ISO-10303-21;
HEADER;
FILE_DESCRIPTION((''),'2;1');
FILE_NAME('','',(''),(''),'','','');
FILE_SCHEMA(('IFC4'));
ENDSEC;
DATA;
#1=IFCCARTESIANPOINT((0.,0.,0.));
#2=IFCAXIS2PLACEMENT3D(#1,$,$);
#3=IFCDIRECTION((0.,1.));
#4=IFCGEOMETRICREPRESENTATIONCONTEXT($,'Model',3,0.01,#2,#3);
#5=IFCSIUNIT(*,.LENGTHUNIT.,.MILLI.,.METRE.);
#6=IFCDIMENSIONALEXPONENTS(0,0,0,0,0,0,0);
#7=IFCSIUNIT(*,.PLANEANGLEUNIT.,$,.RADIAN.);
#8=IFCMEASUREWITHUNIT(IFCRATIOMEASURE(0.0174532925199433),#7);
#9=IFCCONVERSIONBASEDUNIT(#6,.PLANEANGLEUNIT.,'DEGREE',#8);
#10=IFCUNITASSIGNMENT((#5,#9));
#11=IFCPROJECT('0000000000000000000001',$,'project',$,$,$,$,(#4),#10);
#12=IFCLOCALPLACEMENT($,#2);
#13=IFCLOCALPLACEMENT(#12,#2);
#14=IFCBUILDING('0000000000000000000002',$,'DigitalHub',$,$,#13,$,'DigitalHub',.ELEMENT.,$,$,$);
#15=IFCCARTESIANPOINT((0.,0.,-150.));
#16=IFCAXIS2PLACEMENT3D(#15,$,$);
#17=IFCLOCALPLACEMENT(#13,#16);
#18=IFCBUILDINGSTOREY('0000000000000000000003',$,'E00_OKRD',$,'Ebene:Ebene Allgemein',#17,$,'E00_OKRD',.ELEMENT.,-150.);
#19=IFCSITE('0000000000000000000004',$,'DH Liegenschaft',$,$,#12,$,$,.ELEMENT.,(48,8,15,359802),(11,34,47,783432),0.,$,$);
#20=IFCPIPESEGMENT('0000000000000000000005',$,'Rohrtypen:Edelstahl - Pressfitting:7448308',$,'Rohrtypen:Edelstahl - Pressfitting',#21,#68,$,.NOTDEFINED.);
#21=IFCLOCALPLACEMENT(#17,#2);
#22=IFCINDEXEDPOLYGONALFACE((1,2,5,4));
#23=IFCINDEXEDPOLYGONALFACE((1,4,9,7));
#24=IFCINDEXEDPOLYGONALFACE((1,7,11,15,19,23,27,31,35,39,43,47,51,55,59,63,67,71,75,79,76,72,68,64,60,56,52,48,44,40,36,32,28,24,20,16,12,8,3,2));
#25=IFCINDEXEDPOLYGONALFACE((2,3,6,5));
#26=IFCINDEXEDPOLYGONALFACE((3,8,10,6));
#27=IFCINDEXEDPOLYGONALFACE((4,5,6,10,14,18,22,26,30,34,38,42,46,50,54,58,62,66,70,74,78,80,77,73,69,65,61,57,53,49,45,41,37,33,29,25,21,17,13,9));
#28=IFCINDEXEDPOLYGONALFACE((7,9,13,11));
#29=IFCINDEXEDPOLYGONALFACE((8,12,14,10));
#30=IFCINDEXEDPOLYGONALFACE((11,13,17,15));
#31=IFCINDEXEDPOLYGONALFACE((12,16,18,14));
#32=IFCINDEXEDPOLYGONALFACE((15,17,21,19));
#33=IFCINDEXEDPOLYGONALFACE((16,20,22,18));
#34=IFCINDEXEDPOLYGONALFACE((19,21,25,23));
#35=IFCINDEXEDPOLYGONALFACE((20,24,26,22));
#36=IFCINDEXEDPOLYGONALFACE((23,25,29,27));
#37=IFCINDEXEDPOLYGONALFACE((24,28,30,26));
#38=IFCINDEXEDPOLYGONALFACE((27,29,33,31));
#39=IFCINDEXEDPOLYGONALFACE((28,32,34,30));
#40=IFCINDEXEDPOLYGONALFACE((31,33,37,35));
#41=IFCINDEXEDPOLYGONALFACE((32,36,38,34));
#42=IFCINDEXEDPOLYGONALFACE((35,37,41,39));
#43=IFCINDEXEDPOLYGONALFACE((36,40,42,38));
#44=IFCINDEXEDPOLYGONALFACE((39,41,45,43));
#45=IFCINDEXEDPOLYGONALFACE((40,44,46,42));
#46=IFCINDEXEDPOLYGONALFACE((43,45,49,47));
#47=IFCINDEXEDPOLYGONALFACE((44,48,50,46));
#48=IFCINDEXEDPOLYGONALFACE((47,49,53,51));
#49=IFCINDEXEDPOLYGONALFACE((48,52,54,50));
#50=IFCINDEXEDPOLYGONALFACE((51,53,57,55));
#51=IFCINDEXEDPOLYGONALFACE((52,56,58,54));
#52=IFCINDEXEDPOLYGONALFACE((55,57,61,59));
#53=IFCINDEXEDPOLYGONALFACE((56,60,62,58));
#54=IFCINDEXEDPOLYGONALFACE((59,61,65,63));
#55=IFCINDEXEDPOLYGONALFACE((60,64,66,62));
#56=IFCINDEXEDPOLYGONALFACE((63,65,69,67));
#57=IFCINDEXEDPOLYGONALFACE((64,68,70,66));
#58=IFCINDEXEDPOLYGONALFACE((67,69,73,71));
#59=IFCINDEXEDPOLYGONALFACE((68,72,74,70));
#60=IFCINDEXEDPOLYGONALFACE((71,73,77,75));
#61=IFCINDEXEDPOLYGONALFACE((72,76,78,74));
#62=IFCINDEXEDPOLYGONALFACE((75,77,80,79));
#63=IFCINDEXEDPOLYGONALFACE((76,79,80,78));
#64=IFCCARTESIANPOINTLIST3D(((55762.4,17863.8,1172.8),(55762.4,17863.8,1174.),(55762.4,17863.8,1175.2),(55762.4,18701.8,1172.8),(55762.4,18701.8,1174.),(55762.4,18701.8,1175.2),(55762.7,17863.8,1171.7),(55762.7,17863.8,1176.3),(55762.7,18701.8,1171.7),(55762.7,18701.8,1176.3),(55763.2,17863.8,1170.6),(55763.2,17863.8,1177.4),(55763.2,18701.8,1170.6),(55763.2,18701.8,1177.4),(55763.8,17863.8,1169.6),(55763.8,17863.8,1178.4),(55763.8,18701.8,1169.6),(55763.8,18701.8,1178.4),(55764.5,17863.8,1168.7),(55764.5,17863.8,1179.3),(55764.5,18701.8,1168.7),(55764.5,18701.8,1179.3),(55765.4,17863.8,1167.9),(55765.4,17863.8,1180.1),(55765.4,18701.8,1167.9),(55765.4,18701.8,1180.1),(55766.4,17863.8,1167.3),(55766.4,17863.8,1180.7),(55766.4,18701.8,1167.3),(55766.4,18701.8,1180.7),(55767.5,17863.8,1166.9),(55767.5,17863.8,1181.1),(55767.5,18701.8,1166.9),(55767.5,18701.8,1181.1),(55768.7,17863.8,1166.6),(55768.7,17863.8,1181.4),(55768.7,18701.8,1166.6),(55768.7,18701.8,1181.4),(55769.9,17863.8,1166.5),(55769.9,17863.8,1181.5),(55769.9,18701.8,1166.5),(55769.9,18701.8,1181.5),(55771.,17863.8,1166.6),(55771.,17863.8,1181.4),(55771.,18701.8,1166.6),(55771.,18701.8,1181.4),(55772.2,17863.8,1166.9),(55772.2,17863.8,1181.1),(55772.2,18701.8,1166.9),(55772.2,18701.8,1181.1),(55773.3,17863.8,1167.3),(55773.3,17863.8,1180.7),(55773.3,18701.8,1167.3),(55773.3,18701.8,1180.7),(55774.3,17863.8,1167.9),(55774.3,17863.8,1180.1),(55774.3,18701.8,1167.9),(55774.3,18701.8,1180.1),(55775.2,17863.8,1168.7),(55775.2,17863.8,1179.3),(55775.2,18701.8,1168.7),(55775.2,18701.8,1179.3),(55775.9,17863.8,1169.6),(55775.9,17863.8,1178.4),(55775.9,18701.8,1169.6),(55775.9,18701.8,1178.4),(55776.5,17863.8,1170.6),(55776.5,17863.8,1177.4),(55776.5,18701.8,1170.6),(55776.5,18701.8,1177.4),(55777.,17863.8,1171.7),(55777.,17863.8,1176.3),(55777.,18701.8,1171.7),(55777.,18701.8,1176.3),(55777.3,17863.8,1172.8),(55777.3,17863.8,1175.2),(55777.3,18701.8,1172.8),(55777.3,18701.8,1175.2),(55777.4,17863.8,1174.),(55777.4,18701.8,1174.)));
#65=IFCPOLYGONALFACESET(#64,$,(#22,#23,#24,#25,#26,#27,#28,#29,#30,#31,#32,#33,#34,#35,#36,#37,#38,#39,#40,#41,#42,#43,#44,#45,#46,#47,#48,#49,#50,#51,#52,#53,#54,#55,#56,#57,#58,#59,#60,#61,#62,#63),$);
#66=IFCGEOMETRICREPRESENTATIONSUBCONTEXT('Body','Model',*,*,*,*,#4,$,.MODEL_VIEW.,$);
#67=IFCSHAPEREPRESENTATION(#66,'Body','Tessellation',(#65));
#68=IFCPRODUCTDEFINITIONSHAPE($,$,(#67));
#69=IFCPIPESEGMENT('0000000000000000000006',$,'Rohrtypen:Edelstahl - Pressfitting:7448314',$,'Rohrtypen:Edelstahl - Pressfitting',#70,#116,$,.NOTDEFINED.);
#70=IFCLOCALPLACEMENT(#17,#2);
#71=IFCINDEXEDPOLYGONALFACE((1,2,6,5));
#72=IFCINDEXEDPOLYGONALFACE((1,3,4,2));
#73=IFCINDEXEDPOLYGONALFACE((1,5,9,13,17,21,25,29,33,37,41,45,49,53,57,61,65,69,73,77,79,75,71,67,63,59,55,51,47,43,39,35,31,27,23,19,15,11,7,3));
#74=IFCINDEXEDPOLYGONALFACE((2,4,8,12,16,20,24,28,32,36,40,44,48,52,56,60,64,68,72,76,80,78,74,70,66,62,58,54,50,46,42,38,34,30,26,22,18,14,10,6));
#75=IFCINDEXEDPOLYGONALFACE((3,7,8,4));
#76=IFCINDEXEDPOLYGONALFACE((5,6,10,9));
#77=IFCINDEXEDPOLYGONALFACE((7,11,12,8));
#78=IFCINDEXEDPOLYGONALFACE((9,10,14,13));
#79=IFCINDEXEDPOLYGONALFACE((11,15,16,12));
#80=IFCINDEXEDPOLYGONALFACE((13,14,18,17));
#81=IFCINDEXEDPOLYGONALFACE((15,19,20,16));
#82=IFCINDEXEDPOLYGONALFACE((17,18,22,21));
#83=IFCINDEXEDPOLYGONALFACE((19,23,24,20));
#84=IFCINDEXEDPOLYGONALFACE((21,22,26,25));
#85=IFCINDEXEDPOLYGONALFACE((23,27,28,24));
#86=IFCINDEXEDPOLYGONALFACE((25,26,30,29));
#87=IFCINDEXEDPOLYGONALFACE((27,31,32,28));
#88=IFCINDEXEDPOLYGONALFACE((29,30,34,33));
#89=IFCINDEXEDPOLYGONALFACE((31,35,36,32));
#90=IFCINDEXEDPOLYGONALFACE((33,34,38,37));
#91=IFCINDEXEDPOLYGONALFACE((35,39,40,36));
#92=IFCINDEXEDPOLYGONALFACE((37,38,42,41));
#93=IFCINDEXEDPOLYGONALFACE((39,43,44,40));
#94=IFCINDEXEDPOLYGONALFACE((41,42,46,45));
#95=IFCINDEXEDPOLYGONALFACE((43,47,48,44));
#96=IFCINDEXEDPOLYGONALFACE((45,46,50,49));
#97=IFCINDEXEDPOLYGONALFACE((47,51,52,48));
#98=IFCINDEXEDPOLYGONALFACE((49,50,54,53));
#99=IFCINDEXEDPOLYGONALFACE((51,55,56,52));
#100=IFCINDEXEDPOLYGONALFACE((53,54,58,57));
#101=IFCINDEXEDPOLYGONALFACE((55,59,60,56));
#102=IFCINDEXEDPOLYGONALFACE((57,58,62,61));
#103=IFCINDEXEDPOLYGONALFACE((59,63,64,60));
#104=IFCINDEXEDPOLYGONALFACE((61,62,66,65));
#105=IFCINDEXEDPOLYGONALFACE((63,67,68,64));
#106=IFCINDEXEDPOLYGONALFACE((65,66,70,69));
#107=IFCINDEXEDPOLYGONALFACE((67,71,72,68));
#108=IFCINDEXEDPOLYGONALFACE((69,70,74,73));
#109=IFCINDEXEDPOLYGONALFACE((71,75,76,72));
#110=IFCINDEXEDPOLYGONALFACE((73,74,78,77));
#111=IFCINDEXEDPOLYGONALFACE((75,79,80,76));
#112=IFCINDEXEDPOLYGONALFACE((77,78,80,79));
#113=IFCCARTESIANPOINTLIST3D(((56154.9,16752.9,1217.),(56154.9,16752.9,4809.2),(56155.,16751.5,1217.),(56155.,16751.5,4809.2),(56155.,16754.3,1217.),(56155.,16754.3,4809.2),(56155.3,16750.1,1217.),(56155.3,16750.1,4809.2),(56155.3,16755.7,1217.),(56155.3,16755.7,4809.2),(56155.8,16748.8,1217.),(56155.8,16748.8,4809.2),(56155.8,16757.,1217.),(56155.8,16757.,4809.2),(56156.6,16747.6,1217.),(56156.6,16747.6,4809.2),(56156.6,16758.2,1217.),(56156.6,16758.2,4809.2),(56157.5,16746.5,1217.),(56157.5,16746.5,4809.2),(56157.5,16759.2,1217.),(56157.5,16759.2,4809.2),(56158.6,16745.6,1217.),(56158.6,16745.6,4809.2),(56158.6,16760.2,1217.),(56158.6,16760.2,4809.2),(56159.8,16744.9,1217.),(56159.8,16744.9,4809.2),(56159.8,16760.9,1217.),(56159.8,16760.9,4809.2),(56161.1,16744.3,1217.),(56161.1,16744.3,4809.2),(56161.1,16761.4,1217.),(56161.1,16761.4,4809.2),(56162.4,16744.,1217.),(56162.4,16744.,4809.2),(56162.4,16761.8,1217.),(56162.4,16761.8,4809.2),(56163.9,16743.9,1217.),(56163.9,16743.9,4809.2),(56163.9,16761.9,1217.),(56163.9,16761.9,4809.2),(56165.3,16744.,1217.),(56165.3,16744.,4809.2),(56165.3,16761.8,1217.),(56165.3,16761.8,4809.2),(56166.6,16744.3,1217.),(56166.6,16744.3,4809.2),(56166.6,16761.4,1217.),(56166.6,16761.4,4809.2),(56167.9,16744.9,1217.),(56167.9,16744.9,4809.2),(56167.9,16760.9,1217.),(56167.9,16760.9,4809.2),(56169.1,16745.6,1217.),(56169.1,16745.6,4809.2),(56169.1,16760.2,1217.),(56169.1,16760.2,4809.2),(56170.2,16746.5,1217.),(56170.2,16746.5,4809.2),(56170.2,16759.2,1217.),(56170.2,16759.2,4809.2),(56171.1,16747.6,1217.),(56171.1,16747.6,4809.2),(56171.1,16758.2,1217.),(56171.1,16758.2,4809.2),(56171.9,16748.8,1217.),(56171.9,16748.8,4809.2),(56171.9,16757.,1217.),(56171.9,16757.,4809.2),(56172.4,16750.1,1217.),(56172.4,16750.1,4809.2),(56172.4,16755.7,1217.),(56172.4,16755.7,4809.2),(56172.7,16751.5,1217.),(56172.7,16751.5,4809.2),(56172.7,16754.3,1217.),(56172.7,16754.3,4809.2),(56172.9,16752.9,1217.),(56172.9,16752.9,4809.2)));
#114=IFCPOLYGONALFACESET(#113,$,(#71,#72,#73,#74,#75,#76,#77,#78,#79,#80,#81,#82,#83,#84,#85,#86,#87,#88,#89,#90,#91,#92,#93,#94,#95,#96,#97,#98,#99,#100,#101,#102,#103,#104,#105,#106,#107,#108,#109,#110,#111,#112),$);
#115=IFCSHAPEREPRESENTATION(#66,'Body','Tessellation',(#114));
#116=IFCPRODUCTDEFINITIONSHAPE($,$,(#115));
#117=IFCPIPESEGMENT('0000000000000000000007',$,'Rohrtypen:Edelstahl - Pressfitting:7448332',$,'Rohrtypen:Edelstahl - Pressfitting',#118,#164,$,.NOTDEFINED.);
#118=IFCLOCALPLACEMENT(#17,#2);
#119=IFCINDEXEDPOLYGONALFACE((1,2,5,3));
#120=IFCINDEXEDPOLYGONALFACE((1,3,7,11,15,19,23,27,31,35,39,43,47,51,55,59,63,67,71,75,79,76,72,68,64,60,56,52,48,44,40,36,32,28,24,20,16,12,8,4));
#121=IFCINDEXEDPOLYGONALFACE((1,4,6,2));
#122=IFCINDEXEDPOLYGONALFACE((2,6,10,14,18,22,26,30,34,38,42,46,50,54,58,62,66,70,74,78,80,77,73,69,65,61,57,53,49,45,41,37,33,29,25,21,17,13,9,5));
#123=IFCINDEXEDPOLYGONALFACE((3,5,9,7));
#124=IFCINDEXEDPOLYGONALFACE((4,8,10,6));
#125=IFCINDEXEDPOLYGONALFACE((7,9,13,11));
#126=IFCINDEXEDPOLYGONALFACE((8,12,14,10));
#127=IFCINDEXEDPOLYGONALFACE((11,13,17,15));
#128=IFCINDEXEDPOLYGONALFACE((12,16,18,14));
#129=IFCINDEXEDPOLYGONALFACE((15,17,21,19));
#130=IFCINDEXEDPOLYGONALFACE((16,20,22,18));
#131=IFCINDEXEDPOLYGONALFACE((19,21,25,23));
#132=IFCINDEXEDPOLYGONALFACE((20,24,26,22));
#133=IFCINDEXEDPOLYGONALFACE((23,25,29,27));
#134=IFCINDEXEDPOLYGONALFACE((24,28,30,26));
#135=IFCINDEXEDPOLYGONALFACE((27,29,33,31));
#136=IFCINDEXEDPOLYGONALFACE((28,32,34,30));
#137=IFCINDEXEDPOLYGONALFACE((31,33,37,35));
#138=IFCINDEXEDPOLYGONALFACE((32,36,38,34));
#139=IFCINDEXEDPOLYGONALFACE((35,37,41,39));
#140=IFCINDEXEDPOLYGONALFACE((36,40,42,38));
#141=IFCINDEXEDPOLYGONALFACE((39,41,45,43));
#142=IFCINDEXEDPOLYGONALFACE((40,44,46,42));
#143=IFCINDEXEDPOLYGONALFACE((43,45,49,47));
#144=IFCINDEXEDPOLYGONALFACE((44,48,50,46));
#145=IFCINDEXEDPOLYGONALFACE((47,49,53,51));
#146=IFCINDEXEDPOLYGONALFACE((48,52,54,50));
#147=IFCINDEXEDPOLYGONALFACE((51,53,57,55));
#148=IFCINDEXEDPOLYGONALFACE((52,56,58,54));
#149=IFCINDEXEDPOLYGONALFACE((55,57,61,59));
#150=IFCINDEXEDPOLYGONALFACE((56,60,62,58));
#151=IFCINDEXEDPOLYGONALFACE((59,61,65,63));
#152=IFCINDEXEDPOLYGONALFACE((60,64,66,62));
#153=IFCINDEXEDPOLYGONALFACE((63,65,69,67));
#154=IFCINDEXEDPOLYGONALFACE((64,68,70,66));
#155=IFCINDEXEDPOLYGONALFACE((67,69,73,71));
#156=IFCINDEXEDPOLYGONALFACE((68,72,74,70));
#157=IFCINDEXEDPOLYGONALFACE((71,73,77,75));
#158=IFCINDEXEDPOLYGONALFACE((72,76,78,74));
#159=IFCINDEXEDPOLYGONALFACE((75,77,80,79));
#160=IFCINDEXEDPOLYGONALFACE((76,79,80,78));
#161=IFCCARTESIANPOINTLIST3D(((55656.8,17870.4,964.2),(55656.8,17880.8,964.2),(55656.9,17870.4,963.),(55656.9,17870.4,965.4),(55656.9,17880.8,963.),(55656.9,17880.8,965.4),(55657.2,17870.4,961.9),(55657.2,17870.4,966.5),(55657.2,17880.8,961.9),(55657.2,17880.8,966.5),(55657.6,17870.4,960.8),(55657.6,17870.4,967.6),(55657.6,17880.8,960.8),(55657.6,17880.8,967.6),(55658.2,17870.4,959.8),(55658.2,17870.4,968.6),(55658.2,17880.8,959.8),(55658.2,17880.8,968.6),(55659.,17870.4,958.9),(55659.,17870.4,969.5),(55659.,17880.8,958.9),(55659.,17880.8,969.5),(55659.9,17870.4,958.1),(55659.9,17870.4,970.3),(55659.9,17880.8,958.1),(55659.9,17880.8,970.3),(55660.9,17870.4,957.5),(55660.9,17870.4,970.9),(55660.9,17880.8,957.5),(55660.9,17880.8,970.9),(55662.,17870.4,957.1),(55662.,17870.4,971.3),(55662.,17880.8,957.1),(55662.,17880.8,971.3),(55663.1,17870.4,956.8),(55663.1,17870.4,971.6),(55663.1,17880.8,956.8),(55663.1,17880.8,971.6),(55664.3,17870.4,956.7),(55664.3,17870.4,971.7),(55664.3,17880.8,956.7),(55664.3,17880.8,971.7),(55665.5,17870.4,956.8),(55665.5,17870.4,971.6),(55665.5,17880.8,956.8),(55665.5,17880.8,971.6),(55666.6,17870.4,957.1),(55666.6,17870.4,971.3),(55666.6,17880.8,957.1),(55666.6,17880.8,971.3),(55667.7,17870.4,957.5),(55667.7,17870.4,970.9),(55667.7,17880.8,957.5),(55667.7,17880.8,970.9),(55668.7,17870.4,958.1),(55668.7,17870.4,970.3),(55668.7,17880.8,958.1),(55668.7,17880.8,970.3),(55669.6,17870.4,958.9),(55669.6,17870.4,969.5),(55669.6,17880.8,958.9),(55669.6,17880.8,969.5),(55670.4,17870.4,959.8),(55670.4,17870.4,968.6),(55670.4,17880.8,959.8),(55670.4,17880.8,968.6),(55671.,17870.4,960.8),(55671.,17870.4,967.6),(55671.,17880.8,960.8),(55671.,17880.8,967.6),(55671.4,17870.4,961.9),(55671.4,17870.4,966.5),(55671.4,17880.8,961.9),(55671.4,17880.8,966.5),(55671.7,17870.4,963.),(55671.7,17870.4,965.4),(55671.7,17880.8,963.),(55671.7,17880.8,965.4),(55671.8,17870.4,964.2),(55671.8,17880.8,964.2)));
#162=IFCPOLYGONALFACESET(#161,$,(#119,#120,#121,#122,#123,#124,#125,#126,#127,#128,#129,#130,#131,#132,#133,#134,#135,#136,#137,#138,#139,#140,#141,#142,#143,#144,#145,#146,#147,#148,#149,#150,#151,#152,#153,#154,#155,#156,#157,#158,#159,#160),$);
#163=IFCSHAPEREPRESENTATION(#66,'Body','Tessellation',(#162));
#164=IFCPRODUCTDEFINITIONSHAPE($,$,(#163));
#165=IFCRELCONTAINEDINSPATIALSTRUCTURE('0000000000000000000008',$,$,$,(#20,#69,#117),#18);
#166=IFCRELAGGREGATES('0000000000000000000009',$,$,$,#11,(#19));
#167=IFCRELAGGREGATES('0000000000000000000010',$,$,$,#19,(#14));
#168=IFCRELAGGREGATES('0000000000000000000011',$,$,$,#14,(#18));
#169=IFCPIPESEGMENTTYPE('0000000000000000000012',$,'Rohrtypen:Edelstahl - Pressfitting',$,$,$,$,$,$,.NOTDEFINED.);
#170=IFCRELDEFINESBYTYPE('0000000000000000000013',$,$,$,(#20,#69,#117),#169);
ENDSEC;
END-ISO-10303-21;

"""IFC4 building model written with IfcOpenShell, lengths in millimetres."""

from ifc_helpers import new_model, entity, si_unit, converted_unit, direction, frame, origin, place, context, subcontext, project, spatial, indexed_curve, outline, extrude, type_object, element, save


model = new_model("IFC4")

# Units and contexts
model_context = context("Model", 3, precision=0.01, world=origin(), true_north=direction((0.0, 1.0)))
body_context = subcontext(model_context, "Body", "Model", "MODEL_VIEW")
ifc_project = project(units=[si_unit("LENGTHUNIT", "METRE", prefix="MILLI"), converted_unit("PLANEANGLEUNIT", "DEGREE", entity("IfcRatioMeasure", 0.0174532925199433), si_unit("PLANEANGLEUNIT", "RADIAN"), dimensions=[0, 0, 0, 0, 0, 0, 0])], contexts=[model_context])

# Site, building, storey
site_placement = place(None, origin())
site = spatial("IfcSite", under=ifc_project, at=site_placement, Name="DH Liegenschaft", CompositionType="ELEMENT", RefLatitude=(48, 8, 15, 359802), RefLongitude=(11, 34, 47, 783432), RefElevation=0.0)
building_placement = place(site_placement, origin())
building = spatial("IfcBuilding", under=site, at=building_placement, Name="DigitalHub", LongName="DigitalHub", CompositionType="ELEMENT")
storey_placement = place(building_placement, frame((0.0, 0.0, -150.0)))
storey = spatial("IfcBuildingStorey", under=building, at=storey_placement, Name="E00_OKRD", ObjectType="Ebene:Ebene Allgemein", LongName="E00_OKRD", CompositionType="ELEMENT", Elevation=-150.0)

# Pipe segments
pipe_segment_type_1 = type_object("IfcPipeSegmentType", Name="Rohrtypen:Edelstahl - Pressfitting", PredefinedType="NOTDEFINED")
pipe_segment_1_placement = place(storey_placement, frame((55760.8, 17863.8, 1164.9)))
element("IfcPipeSegment", 1, at=pipe_segment_1_placement, inside=storey, type_object=pipe_segment_type_1, Name="Rohrtypen:Edelstahl - Pressfitting:7448308", ObjectType="Rohrtypen:Edelstahl - Pressfitting", PredefinedType="NOTDEFINED", context=body_context, shape_type="SweptSolid", body=[
    extrude(outline(indexed_curve([(7.5, 0.0), (7.4, 1.2), (7.1, 2.3), (6.7, 3.4), (6.1, 4.4), (5.3, 5.3), (4.4, 6.1), (3.4, 6.7), (2.3, 7.1), (1.2, 7.4), (0.0, 7.5), (-1.2, 7.4), (-2.3, 7.1), (-3.4, 6.7), (-4.4, 6.1), (-5.3, 5.3), (-6.1, 4.4), (-6.7, 3.4), (-7.1, 2.3), (-7.4, 1.2), (-7.5, 0.0), (-7.4, -1.2), (-7.1, -2.3), (-6.7, -3.4), (-6.1, -4.4), (-5.3, -5.3), (-4.4, -6.1), (-3.4, -6.7), (-2.3, -7.1), (-1.2, -7.4), (0.0, -7.5), (1.2, -7.4), (2.3, -7.1), (3.4, -6.7), (4.4, -6.1), (5.3, -5.3), (6.1, -4.4), (6.7, -3.4), (7.1, -2.3), (7.4, -1.2), (7.5, 0.0)], self_intersect=False)), frame((9.1, 0.0, 9.1), z_axis=(0.0, 1.0, 0.0), x_axis=(1.0, 0.0, 0.0)), (0.0, 0.0, 1.0), 838.0),
])
pipe_segment_2_placement = place(storey_placement, frame((56153.3, 16742.3, 1217.0)))
element("IfcPipeSegment", 2, at=pipe_segment_2_placement, inside=storey, type_object=pipe_segment_type_1, Name="Rohrtypen:Edelstahl - Pressfitting:7448314", ObjectType="Rohrtypen:Edelstahl - Pressfitting", PredefinedType="NOTDEFINED", context=body_context, shape_type="SweptSolid", body=[
    extrude(outline(indexed_curve([(9.0, 0.0), (8.9, 1.4), (8.6, 2.8), (8.0, 4.1), (7.3, 5.3), (6.4, 6.4), (5.3, 7.3), (4.1, 8.0), (2.8, 8.6), (1.4, 8.9), (0.0, 9.0), (-1.4, 8.9), (-2.8, 8.6), (-4.1, 8.0), (-5.3, 7.3), (-6.4, 6.4), (-7.3, 5.3), (-8.0, 4.1), (-8.6, 2.8), (-8.9, 1.4), (-9.0, 0.0), (-8.9, -1.4), (-8.6, -2.8), (-8.0, -4.1), (-7.3, -5.3), (-6.4, -6.4), (-5.3, -7.3), (-4.1, -8.0), (-2.8, -8.6), (-1.4, -8.9), (0.0, -9.0), (1.4, -8.9), (2.8, -8.6), (4.1, -8.0), (5.3, -7.3), (6.4, -6.4), (7.3, -5.3), (8.0, -4.1), (8.6, -2.8), (8.9, -1.4), (9.0, 0.0)], self_intersect=False)), frame((10.6, 10.6, 0.0)), (0.0, 0.0, 1.0), 3592.2),
])
pipe_segment_3_placement = place(storey_placement, frame((55655.2, 17870.4, 955.1)))
element("IfcPipeSegment", 3, at=pipe_segment_3_placement, inside=storey, type_object=pipe_segment_type_1, Name="Rohrtypen:Edelstahl - Pressfitting:7448332", ObjectType="Rohrtypen:Edelstahl - Pressfitting", PredefinedType="NOTDEFINED", context=body_context, shape_type="SweptSolid", body=[
    extrude(outline(indexed_curve([(7.5, 0.0), (7.4, 1.2), (7.1, 2.3), (6.7, 3.4), (6.1, 4.4), (5.3, 5.3), (4.4, 6.1), (3.4, 6.7), (2.3, 7.1), (1.2, 7.4), (0.0, 7.5), (-1.2, 7.4), (-2.3, 7.1), (-3.4, 6.7), (-4.4, 6.1), (-5.3, 5.3), (-6.1, 4.4), (-6.7, 3.4), (-7.1, 2.3), (-7.4, 1.2), (-7.5, 0.0), (-7.4, -1.2), (-7.1, -2.3), (-6.7, -3.4), (-6.1, -4.4), (-5.3, -5.3), (-4.4, -6.1), (-3.4, -6.7), (-2.3, -7.1), (-1.2, -7.4), (0.0, -7.5), (1.2, -7.4), (2.3, -7.1), (3.4, -6.7), (4.4, -6.1), (5.3, -5.3), (6.1, -4.4), (6.7, -3.4), (7.1, -2.3), (7.4, -1.2), (7.5, 0.0)], self_intersect=False)), frame((9.1, 0.0, 9.1), z_axis=(0.0, 1.0, 0.0), x_axis=(-1.0, 0.0, 0.0)), (0.0, 0.0, 1.0), 10.4),
])

save(model, "model.ifc")
